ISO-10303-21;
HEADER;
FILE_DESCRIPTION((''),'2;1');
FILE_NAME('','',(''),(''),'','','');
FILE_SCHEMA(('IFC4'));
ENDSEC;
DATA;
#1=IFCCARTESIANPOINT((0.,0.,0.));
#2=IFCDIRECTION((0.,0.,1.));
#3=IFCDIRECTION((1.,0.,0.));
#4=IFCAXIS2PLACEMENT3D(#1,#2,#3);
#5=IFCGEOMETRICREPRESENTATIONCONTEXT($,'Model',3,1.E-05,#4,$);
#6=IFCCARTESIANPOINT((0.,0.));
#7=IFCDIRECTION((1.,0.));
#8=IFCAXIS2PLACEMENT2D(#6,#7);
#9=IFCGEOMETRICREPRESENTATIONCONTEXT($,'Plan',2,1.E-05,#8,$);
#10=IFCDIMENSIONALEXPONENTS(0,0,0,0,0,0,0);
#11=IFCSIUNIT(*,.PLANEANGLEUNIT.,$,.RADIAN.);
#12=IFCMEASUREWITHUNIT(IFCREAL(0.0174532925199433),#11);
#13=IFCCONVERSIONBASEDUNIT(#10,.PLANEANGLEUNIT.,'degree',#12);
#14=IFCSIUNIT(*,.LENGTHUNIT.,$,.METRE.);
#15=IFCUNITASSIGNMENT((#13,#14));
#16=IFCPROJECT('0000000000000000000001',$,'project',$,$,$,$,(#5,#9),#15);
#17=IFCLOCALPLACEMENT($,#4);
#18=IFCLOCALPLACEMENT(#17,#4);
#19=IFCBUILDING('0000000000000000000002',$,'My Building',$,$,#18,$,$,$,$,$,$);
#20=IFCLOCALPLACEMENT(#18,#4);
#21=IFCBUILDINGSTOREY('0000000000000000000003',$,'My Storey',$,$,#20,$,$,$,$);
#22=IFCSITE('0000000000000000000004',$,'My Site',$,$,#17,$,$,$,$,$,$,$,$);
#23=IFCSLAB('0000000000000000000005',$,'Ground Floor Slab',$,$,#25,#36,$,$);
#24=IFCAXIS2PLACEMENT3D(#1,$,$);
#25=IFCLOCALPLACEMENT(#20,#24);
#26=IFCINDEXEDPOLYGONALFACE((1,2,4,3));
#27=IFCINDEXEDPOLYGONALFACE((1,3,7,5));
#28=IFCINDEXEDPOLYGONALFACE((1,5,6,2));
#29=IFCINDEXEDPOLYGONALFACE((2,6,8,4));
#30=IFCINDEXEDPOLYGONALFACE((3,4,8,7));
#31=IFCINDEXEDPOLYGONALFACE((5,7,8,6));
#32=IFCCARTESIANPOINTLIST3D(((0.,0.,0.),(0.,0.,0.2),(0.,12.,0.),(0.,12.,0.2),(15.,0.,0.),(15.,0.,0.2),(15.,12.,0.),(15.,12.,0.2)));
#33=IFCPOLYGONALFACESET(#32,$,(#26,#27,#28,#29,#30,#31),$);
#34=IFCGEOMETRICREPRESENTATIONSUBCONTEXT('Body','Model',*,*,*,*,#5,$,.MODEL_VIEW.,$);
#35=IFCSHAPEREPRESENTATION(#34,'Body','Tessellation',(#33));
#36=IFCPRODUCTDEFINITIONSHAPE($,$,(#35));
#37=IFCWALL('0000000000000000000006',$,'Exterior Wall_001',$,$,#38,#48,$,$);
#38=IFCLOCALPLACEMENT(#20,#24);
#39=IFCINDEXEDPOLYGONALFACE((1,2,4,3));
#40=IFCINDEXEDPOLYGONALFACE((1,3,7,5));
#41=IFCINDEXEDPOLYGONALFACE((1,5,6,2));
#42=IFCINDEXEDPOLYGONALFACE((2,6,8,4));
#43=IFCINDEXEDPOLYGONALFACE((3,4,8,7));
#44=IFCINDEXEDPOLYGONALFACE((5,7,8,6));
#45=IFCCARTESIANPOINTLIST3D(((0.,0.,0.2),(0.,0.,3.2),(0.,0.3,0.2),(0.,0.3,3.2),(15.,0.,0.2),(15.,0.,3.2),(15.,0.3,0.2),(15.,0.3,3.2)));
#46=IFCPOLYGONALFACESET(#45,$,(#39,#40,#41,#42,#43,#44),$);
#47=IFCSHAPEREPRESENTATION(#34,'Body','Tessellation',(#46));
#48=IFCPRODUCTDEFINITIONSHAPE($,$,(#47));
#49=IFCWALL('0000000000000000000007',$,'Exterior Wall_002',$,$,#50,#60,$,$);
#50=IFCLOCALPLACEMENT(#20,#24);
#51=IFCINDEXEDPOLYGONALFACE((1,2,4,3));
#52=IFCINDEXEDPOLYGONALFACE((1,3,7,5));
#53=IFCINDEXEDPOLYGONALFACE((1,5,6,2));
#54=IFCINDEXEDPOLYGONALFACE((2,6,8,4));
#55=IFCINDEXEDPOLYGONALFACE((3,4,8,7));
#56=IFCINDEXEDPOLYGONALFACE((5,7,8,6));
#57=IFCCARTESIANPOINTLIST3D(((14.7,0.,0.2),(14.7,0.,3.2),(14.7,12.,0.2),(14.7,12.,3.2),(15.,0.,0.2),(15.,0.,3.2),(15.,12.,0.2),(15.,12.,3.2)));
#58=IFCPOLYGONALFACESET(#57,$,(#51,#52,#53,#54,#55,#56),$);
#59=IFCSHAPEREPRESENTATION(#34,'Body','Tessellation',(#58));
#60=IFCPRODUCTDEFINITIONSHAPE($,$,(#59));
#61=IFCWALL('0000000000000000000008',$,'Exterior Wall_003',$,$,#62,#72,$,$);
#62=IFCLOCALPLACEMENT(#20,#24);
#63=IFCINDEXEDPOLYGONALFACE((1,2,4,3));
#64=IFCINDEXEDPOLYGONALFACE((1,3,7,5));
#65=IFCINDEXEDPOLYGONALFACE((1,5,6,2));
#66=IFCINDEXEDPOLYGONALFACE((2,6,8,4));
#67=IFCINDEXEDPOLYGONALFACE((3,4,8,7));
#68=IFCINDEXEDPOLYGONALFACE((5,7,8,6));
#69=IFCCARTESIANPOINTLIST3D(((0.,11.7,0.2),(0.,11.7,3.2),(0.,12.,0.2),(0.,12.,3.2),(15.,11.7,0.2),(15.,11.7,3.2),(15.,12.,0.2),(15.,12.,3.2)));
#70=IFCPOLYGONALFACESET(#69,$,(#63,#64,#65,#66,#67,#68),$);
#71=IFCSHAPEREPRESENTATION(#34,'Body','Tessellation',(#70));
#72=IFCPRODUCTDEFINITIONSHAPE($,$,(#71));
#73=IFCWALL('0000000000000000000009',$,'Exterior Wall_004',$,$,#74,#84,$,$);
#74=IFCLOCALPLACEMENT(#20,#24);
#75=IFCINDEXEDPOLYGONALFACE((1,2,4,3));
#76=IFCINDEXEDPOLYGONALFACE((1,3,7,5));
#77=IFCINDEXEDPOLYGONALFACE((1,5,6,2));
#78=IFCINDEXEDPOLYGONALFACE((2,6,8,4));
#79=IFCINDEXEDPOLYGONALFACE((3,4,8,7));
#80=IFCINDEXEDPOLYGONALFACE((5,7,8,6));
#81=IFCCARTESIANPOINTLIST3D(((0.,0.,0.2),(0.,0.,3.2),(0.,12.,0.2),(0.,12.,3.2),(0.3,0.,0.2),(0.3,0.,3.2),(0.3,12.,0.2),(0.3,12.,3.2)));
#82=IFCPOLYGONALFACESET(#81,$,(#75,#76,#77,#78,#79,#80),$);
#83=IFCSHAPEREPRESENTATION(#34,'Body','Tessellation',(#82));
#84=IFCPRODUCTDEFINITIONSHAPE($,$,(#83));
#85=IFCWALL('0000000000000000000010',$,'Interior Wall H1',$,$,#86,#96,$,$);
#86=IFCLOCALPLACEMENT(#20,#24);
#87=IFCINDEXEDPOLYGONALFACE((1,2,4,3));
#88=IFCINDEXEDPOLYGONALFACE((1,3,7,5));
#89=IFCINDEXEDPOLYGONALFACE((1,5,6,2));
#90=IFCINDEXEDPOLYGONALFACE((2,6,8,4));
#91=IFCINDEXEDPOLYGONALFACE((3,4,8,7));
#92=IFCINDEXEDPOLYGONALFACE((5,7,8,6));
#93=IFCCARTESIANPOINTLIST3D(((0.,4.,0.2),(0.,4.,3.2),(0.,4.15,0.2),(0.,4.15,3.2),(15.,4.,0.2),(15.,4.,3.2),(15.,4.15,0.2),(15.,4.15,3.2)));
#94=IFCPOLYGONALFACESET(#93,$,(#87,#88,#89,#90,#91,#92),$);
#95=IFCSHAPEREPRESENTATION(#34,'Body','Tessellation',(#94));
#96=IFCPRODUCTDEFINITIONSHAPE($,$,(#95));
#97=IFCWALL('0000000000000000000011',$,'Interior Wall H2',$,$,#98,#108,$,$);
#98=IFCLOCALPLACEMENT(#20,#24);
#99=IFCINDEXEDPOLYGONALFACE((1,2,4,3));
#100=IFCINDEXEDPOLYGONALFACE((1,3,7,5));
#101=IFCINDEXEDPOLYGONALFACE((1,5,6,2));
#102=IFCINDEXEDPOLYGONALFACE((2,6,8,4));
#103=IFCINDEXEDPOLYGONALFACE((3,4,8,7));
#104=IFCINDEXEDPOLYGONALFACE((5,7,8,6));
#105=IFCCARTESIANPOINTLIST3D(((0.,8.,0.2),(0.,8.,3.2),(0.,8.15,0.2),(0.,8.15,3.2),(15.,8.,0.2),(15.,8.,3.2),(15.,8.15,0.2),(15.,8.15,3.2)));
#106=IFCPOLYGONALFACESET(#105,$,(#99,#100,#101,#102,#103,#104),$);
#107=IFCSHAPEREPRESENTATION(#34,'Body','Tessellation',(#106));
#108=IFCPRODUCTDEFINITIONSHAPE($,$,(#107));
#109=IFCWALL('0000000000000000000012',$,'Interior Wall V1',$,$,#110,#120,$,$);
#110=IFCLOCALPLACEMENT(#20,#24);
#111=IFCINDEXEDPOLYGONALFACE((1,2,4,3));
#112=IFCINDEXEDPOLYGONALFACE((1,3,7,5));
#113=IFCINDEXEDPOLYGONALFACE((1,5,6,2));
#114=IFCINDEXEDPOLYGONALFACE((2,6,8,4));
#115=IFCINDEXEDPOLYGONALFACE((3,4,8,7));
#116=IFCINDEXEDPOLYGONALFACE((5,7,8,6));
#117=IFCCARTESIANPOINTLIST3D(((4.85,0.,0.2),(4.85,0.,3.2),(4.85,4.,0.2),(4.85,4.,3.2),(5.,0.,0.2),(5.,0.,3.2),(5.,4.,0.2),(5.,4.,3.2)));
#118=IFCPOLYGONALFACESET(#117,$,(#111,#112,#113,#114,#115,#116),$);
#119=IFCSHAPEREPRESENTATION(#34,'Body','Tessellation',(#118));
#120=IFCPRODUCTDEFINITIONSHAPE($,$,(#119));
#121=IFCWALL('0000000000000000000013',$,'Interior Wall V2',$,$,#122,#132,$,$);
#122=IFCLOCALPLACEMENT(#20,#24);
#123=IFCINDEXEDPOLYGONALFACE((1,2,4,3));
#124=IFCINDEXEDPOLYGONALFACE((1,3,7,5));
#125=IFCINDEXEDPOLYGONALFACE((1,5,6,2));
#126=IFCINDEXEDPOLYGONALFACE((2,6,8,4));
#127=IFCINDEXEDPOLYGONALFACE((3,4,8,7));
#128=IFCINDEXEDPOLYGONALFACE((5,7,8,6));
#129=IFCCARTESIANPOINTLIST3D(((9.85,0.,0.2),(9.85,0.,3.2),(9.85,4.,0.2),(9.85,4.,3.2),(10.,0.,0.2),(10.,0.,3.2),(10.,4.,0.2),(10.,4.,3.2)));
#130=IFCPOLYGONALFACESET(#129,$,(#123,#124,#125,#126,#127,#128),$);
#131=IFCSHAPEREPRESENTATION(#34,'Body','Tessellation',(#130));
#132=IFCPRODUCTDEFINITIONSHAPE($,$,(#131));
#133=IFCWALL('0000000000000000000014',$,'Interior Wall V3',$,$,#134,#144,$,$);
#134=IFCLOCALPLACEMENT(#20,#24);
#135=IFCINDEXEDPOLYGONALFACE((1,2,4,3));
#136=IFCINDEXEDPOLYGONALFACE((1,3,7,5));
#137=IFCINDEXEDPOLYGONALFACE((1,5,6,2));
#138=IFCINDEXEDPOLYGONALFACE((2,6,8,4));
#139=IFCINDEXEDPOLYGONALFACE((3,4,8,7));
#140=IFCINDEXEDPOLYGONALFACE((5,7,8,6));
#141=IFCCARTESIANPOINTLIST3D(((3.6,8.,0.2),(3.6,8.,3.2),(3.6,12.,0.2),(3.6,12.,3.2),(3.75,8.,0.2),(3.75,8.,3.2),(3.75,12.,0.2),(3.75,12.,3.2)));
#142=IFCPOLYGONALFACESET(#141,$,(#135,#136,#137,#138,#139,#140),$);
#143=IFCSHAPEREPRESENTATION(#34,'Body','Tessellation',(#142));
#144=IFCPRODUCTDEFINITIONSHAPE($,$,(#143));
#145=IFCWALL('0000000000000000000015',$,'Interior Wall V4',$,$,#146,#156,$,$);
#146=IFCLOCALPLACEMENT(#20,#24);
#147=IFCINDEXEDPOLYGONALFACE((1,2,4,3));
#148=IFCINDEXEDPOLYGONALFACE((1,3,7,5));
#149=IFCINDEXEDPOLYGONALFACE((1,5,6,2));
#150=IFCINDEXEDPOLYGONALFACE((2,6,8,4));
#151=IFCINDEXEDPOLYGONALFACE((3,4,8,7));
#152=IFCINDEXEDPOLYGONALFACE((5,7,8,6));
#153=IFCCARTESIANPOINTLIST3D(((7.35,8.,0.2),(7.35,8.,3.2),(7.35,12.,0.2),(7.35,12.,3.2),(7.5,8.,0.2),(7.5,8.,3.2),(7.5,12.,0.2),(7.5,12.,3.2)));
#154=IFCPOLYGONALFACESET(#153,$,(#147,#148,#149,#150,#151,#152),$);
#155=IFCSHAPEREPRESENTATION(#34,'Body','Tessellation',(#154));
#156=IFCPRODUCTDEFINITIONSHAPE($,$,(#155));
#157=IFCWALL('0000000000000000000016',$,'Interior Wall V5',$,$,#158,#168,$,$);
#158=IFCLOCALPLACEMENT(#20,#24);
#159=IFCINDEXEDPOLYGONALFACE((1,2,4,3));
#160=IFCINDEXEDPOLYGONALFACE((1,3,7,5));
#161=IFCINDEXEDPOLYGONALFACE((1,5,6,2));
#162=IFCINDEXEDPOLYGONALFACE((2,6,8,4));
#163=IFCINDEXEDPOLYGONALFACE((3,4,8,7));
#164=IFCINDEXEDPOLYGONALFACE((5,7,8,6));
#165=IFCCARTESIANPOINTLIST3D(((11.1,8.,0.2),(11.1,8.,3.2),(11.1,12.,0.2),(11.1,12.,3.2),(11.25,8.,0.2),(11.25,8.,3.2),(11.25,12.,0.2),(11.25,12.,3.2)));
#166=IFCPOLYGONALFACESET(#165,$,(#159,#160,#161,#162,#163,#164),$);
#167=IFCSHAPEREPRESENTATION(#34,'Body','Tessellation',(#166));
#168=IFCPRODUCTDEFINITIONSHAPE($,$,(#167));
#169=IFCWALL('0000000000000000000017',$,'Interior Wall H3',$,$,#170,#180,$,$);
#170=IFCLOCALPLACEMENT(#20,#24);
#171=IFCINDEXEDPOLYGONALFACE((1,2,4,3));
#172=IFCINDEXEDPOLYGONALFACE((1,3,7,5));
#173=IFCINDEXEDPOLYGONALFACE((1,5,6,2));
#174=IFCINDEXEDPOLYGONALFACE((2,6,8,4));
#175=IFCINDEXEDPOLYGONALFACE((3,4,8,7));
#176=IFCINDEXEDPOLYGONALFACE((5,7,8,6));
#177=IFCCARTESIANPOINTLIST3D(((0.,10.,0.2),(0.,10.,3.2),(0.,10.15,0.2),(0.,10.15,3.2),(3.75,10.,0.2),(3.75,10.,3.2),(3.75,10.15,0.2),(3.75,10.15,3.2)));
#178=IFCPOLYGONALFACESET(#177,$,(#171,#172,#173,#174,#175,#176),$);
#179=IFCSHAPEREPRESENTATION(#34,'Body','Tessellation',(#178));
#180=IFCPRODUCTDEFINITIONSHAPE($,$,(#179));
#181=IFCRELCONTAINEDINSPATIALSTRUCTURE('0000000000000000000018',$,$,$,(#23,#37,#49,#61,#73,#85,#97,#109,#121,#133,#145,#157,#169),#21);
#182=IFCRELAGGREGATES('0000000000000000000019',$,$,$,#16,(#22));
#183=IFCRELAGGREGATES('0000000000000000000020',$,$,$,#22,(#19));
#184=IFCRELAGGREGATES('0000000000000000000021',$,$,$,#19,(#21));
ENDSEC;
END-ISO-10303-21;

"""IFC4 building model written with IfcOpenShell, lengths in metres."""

from ifc_helpers import new_model, entity, si_unit, converted_unit, frame, origin_with_axes, origin_2d_with_axis, place, context, subcontext, project, spatial, indexed_curve, outline, extrude, element, save


model = new_model("IFC4")

# Units and contexts
model_context = context("Model", 3, precision=1e-05, world=origin_with_axes())
plan_context = context("Plan", 2, precision=1e-05, world=origin_2d_with_axis())
body_context = subcontext(model_context, "Body", "Model", "MODEL_VIEW")
ifc_project = project(units=[converted_unit("PLANEANGLEUNIT", "degree", entity("IfcReal", 0.0174532925199433), si_unit("PLANEANGLEUNIT", "RADIAN"), dimensions=[0, 0, 0, 0, 0, 0, 0]), si_unit("LENGTHUNIT", "METRE")], contexts=[model_context, plan_context])

# Site, building, storey
site_placement = place(None, origin_with_axes())
site = spatial("IfcSite", under=ifc_project, at=site_placement, Name="My Site")
building_placement = place(site_placement, origin_with_axes())
building = spatial("IfcBuilding", under=site, at=building_placement, Name="My Building")
storey_placement = place(building_placement, origin_with_axes())
storey = spatial("IfcBuildingStorey", under=building, at=storey_placement, Name="My Storey")

# Slab
slab_placement = place(storey_placement, origin_with_axes())
element("IfcSlab", 1, at=slab_placement, inside=storey, Name="Ground Floor Slab", context=body_context, shape_type="SweptSolid", body=[
    extrude(outline(indexed_curve([(0.0, 0.0), (15.0, 0.0), (15.0, 12.0), (0.0, 12.0)])), None, (0.0, 0.0, 1.0), 0.2),
])

# Walls
wall_1_placement = place(storey_placement, frame((0.0, 0.0, 0.2), z_axis=(0.0, 0.0, 1.0), x_axis=(1.0, 0.0, 0.0)))
element("IfcWall", 2, at=wall_1_placement, inside=storey, Name="Exterior Wall_001", context=body_context, shape_type="SweptSolid", body=[
    extrude(outline(indexed_curve([(0.0, 0.0), (0.0, 0.3), (15.0, 0.3), (15.0, 0.0), (0.0, 0.0)], self_intersect=False)), origin_with_axes(), (0.0, 0.0, 1.0), 3.0),
])
wall_2_placement = place(storey_placement, frame((15.0, 0.0, 0.2), z_axis=(0.0, 0.0, 1.0), x_axis=(0.0, 1.0, 0.0)))
element("IfcWall", 3, at=wall_2_placement, inside=storey, Name="Exterior Wall_002", context=body_context, shape_type="SweptSolid", body=[
    extrude(outline(indexed_curve([(0.0, 0.0), (0.0, 0.3), (12.0, 0.3), (12.0, 0.0), (0.0, 0.0)], self_intersect=False)), origin_with_axes(), (0.0, 0.0, 1.0), 3.0),
])
wall_3_placement = place(storey_placement, frame((15.0, 12.0, 0.2), z_axis=(0.0, 0.0, 1.0), x_axis=(-1.0, 0.0, 0.0)))
element("IfcWall", 4, at=wall_3_placement, inside=storey, Name="Exterior Wall_003", context=body_context, shape_type="SweptSolid", body=[
    extrude(outline(indexed_curve([(0.0, 0.0), (0.0, 0.3), (15.0, 0.3), (15.0, 0.0), (0.0, 0.0)], self_intersect=False)), origin_with_axes(), (0.0, 0.0, 1.0), 3.0),
])
wall_4_placement = place(storey_placement, frame((0.0, 12.0, 0.2), z_axis=(0.0, 0.0, 1.0), x_axis=(0.0, -1.0, 0.0)))
element("IfcWall", 5, at=wall_4_placement, inside=storey, Name="Exterior Wall_004", context=body_context, shape_type="SweptSolid", body=[
    extrude(outline(indexed_curve([(0.0, 0.0), (0.0, 0.3), (12.0, 0.3), (12.0, 0.0), (0.0, 0.0)], self_intersect=False)), origin_with_axes(), (0.0, 0.0, 1.0), 3.0),
])
for number, where, z_axis, x_axis, name in (
    (6, (0.0, 4.0, 0.2), (0.0, 0.0, 1.0), (1.0, 0.0, 0.0), "Interior Wall H1"),
    (7, (0.0, 8.0, 0.2), (0.0, 0.0, 1.0), (1.0, 0.0, 0.0), "Interior Wall H2"),
):
    element("IfcWall", number, at=place(storey_placement, frame(where, z_axis=z_axis, x_axis=x_axis)), inside=storey, Name=name, context=body_context, shape_type="SweptSolid", body=[
        extrude(outline(indexed_curve([(0.0, 0.0), (0.0, 0.15), (15.0, 0.15), (15.0, 0.0), (0.0, 0.0)], self_intersect=False)), origin_with_axes(), (0.0, 0.0, 1.0), 3.0),
    ])
for number, where, z_axis, x_axis, name in (
    (8, (5.0, 0.0, 0.2), (0.0, 0.0, 1.0), (0.0, 1.0, 0.0), "Interior Wall V1"),
    (9, (10.0, 0.0, 0.2), (0.0, 0.0, 1.0), (0.0, 1.0, 0.0), "Interior Wall V2"),
    (10, (3.75, 8.0, 0.2), (0.0, 0.0, 1.0), (0.0, 1.0, 0.0), "Interior Wall V3"),
    (11, (7.5, 8.0, 0.2), (0.0, 0.0, 1.0), (0.0, 1.0, 0.0), "Interior Wall V4"),
    (12, (11.25, 8.0, 0.2), (0.0, 0.0, 1.0), (0.0, 1.0, 0.0), "Interior Wall V5"),
):
    element("IfcWall", number, at=place(storey_placement, frame(where, z_axis=z_axis, x_axis=x_axis)), inside=storey, Name=name, context=body_context, shape_type="SweptSolid", body=[
        extrude(outline(indexed_curve([(0.0, 0.0), (0.0, 0.15), (4.0, 0.15), (4.0, 0.0), (0.0, 0.0)], self_intersect=False)), origin_with_axes(), (0.0, 0.0, 1.0), 3.0),
    ])
wall_5_placement = place(storey_placement, frame((0.0, 10.0, 0.2), z_axis=(0.0, 0.0, 1.0), x_axis=(1.0, 0.0, 0.0)))
element("IfcWall", 13, at=wall_5_placement, inside=storey, Name="Interior Wall H3", context=body_context, shape_type="SweptSolid", body=[
    extrude(outline(indexed_curve([(0.0, 0.0), (0.0, 0.15), (3.75, 0.15), (3.75, 0.0), (0.0, 0.0)], self_intersect=False)), origin_with_axes(), (0.0, 0.0, 1.0), 3.0),
])

save(model, "model.ifc")
